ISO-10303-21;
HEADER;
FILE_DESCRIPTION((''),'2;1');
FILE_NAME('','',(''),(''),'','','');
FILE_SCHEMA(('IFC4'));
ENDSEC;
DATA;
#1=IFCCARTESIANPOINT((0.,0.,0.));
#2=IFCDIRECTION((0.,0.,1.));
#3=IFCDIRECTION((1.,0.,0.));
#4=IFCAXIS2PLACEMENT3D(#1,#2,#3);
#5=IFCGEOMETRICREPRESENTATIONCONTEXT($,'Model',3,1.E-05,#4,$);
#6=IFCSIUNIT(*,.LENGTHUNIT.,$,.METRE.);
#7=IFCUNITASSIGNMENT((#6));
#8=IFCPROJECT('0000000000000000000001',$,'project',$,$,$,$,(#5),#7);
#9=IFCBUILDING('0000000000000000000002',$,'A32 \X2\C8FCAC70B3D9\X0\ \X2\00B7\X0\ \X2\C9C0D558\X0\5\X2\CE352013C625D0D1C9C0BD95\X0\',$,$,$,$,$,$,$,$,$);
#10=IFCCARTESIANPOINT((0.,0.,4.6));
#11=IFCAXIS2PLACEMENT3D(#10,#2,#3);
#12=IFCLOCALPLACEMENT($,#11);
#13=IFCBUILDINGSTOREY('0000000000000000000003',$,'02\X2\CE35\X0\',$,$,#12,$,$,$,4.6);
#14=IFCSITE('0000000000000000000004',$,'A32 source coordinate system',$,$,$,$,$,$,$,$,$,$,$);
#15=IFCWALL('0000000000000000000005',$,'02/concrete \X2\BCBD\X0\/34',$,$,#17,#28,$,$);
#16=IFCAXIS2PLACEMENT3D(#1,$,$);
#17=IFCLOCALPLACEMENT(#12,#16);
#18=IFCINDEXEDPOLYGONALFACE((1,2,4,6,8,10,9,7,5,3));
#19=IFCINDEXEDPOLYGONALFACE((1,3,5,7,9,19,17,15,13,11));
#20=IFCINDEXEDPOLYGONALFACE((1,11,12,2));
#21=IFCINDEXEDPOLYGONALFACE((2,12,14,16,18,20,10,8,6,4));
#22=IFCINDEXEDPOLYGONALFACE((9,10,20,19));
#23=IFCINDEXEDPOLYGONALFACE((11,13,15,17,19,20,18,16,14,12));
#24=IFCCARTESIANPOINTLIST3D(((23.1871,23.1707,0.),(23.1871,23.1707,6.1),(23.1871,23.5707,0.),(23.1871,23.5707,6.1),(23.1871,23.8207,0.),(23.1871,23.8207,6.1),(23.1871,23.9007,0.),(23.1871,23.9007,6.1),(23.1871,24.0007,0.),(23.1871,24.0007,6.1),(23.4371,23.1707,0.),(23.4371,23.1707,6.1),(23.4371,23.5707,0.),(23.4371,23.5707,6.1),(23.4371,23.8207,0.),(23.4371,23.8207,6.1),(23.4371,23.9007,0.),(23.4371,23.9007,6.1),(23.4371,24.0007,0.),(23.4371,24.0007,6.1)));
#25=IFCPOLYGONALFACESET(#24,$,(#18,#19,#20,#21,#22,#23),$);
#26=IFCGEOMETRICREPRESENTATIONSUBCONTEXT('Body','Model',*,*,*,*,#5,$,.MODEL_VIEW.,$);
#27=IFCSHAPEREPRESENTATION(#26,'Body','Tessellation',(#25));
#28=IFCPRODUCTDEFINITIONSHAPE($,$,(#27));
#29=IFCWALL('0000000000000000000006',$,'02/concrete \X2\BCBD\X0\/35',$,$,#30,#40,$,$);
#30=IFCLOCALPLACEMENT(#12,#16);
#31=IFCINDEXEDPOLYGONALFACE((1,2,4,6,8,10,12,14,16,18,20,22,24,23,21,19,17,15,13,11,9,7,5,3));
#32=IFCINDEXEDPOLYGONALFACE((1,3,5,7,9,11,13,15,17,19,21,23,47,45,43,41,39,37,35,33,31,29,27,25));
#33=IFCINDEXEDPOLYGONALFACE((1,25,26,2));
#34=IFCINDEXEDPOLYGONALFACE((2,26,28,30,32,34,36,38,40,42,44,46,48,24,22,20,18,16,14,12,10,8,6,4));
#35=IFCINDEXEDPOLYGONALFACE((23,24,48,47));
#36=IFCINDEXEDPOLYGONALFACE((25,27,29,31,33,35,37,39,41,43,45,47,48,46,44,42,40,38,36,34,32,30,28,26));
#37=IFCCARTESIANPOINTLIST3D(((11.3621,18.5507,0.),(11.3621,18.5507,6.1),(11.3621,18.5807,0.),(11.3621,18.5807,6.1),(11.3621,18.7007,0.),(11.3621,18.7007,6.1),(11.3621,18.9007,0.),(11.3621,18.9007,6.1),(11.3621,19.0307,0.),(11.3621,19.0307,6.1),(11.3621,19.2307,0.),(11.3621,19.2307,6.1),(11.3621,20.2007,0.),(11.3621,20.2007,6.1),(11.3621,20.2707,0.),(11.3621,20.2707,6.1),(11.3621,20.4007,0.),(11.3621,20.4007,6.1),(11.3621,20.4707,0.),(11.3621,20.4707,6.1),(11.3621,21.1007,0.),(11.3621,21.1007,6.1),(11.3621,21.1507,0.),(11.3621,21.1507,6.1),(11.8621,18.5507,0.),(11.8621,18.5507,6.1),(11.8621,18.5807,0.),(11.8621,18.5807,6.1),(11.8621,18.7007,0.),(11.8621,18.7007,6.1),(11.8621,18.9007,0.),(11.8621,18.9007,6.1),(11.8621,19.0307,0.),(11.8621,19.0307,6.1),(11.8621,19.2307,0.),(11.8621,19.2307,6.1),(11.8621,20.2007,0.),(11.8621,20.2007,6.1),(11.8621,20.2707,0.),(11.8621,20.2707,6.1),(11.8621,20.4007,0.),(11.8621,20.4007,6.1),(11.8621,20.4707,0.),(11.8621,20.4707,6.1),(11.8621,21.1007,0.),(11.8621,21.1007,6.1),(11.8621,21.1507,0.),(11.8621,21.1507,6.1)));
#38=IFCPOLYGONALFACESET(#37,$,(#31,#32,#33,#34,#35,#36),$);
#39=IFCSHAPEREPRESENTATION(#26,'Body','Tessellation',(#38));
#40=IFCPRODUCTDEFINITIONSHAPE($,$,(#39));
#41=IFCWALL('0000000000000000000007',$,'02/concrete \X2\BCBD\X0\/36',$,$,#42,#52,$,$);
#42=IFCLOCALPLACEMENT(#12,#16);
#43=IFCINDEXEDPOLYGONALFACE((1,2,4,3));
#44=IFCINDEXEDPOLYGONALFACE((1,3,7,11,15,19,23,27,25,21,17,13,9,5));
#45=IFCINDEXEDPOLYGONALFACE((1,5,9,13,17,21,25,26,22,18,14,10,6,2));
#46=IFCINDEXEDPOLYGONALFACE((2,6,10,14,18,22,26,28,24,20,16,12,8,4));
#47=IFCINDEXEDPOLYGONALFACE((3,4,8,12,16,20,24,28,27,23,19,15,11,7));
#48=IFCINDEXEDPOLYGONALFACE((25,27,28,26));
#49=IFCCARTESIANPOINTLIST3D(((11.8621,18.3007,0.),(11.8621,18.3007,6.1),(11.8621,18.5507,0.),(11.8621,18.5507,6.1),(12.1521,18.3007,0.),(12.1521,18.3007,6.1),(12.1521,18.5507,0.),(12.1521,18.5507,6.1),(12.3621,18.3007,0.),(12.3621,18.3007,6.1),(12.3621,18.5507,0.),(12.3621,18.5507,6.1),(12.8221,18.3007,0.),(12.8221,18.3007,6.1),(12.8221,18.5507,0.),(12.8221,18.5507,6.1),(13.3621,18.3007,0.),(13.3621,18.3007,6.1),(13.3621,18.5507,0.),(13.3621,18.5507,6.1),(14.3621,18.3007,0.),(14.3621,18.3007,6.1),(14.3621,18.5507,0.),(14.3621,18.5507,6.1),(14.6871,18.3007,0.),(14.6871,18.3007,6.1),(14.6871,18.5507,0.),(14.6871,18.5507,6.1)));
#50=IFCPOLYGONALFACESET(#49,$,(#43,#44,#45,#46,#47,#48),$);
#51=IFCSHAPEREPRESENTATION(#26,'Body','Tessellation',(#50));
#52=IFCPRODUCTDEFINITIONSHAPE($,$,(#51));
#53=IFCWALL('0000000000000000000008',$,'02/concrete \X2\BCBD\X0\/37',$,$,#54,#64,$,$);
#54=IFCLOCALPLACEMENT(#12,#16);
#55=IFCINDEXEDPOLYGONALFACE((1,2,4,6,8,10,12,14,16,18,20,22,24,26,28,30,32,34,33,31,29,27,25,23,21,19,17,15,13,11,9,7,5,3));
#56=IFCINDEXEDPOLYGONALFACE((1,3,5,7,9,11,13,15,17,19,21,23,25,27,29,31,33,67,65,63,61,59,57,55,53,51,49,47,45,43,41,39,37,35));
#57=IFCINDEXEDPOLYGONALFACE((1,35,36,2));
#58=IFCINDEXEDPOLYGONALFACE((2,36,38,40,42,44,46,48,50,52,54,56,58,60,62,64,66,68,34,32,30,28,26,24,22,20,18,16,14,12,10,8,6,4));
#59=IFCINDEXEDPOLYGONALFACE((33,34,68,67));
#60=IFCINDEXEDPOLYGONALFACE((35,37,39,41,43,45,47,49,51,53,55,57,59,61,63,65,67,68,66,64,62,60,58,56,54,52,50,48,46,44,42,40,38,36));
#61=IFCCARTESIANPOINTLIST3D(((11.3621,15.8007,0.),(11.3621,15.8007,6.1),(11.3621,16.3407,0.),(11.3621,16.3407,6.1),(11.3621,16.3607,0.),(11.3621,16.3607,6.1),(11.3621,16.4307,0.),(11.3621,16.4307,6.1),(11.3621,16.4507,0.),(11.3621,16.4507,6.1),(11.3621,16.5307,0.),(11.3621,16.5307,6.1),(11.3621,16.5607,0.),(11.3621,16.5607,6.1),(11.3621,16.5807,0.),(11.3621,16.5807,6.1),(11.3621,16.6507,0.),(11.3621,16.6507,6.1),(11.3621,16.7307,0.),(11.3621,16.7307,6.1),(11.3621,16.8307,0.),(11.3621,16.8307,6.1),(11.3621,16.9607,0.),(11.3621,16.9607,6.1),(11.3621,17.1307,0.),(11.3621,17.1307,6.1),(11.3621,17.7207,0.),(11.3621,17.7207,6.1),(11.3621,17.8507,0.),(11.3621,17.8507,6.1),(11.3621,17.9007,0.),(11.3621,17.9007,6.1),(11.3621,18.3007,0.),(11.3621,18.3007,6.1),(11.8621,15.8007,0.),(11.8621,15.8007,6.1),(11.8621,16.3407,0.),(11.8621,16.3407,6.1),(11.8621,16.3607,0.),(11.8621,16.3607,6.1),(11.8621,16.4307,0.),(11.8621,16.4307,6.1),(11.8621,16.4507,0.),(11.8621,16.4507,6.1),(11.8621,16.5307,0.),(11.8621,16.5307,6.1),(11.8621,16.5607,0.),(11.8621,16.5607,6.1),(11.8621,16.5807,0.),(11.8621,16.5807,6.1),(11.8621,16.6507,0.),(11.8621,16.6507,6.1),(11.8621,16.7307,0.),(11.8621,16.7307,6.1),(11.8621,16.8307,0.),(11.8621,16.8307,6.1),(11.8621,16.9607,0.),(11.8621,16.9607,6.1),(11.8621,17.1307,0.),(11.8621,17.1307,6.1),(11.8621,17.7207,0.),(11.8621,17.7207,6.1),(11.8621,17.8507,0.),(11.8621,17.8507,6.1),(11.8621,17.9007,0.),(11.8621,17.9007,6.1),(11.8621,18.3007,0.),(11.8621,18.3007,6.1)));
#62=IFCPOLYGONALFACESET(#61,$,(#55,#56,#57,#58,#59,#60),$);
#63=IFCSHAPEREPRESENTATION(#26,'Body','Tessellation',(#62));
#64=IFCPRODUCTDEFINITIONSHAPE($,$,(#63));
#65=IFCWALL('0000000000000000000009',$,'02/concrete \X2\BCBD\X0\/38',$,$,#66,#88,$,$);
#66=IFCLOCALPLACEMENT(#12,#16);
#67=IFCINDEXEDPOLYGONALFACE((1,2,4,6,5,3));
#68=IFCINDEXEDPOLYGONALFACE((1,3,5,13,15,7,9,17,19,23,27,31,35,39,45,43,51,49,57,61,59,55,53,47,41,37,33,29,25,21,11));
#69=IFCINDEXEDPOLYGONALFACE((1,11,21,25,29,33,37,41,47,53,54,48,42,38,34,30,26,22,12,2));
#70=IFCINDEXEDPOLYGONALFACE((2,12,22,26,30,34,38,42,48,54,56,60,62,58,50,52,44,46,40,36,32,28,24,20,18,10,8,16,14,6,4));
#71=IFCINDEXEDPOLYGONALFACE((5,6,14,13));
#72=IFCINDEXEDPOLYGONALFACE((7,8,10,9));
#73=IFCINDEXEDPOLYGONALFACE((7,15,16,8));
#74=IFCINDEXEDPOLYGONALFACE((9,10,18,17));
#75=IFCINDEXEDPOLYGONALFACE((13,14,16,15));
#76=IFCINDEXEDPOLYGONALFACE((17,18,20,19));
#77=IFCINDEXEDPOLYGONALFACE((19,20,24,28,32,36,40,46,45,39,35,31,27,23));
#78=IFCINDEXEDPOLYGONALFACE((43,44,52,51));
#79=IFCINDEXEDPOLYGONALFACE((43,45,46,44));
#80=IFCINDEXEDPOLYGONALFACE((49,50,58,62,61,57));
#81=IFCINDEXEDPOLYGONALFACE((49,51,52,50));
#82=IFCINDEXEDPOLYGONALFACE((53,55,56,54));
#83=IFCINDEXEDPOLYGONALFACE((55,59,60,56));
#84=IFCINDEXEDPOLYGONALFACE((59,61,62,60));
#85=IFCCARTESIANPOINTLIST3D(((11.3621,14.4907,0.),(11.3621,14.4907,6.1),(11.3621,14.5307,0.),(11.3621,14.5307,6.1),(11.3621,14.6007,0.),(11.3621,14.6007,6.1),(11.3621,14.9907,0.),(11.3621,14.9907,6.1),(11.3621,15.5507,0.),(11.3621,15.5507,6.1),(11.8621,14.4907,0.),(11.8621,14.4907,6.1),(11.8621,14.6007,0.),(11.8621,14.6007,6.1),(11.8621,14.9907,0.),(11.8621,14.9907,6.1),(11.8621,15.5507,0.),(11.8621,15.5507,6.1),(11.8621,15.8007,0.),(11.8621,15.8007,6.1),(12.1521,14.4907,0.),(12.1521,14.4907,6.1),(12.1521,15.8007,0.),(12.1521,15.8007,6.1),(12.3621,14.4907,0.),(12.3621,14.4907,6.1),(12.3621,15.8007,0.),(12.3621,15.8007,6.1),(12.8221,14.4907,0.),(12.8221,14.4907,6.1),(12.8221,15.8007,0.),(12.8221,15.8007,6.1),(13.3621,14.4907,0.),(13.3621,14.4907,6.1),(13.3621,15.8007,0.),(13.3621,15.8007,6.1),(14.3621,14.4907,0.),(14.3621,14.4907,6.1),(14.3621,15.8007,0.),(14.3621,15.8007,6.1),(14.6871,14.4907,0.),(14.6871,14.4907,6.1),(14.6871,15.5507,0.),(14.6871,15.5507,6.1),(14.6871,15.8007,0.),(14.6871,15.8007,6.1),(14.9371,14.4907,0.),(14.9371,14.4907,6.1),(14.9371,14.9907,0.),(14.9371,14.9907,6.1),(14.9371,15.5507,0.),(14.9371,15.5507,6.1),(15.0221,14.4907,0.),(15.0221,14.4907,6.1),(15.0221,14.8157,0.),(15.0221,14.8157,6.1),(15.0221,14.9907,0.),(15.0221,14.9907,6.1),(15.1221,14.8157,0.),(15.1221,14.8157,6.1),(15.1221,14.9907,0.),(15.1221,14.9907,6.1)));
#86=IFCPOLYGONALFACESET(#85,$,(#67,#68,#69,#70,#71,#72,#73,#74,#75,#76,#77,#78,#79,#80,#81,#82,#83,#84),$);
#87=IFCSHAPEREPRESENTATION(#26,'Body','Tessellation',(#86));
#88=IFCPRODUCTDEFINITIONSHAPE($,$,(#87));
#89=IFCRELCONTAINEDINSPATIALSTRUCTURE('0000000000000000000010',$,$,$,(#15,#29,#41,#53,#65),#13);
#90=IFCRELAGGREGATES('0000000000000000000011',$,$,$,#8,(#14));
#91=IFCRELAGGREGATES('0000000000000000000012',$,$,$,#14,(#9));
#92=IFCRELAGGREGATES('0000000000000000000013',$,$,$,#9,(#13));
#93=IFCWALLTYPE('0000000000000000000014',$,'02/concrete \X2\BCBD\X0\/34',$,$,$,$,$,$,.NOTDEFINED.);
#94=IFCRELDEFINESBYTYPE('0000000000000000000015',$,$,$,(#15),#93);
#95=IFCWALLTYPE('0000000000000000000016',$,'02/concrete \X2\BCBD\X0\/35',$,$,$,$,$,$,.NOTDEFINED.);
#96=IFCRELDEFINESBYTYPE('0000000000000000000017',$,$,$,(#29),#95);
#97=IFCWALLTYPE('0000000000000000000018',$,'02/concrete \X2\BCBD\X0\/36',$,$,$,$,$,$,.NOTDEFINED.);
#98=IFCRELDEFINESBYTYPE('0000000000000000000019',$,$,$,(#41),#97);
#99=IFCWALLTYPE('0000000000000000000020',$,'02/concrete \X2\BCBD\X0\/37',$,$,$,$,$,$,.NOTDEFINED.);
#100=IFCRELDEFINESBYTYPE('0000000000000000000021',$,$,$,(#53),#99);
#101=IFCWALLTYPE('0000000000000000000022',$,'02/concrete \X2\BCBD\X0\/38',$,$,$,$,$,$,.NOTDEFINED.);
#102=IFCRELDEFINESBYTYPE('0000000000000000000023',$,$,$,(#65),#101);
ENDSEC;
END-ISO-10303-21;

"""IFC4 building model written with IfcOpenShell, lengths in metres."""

from ifc_helpers import new_model, si_unit, frame, origin, origin_with_axes, place, context, subcontext, project, spatial, polyline, outline, extrude, source, transform, mapped, type_object, type_shapes, element, save


model = new_model("IFC4")

# Units and contexts
model_context = context("Model", 3, precision=1e-05, world=origin_with_axes())
body_context = subcontext(model_context, "Body", "Model", "MODEL_VIEW")
ifc_project = project(units=[si_unit("LENGTHUNIT", "METRE")], contexts=[model_context])

# Site, building, storey
site = spatial("IfcSite", under=ifc_project, Name="A32 source coordinate system")
building = spatial("IfcBuilding", under=site, Name="A32 주거동 · 지하5층–옥탑지붕")
storey_placement = place(None, frame((0.0, 0.0, 4.6), z_axis=(0.0, 0.0, 1.0), x_axis=(1.0, 0.0, 0.0)))
storey = spatial("IfcBuildingStorey", under=building, at=storey_placement, Name="02층", Elevation=4.6)

# Walls
wall_type_1 = type_object("IfcWallType", Name="02/concrete 벽/34", PredefinedType="NOTDEFINED")
shared_shape_1 = source(origin(), body_context, "Body", "SweptSolid", [
    extrude(outline(polyline([(23.4371, 23.5707), (23.4371, 23.1707), (23.1871, 23.1707), (23.1871, 23.5707), (23.1871, 23.8207), (23.1871, 23.9007), (23.1871, 24.0007), (23.4371, 24.0007), (23.4371, 23.9007), (23.4371, 23.8207), (23.4371, 23.5707)])), origin(), (0.0, 0.0, 1.0), 6.1),
])
type_shapes(wall_type_1, [shared_shape_1])
wall_1_placement = place(storey_placement, origin_with_axes())
element("IfcWall", 1, at=wall_1_placement, inside=storey, type_object=wall_type_1, Name="02/concrete 벽/34", context=body_context, shape_type="MappedRepresentation", body=[
    mapped(shared_shape_1, transform((0.0, 0.0, 0.0), scale=1.0)),
])
wall_type_2 = type_object("IfcWallType", Name="02/concrete 벽/35", PredefinedType="NOTDEFINED")
shared_shape_2 = source(origin(), body_context, "Body", "SweptSolid", [
    extrude(outline(polyline([(11.3621, 19.0307), (11.3621, 19.2307), (11.3621, 20.2007), (11.3621, 20.2707), (11.3621, 20.4007), (11.3621, 20.4707), (11.3621, 21.1007), (11.3621, 21.1507), (11.8621, 21.1507), (11.8621, 21.1007), (11.8621, 20.4707), (11.8621, 20.4007), (11.8621, 20.2707), (11.8621, 20.2007), (11.8621, 19.2307), (11.8621, 19.0307), (11.8621, 18.9007), (11.8621, 18.7007), (11.8621, 18.5807), (11.8621, 18.5507), (11.3621, 18.5507), (11.3621, 18.5807), (11.3621, 18.7007), (11.3621, 18.9007), (11.3621, 19.0307)])), origin(), (0.0, 0.0, 1.0), 6.1),
])
type_shapes(wall_type_2, [shared_shape_2])
wall_2_placement = place(storey_placement, origin_with_axes())
element("IfcWall", 2, at=wall_2_placement, inside=storey, type_object=wall_type_2, Name="02/concrete 벽/35", context=body_context, shape_type="MappedRepresentation", body=[
    mapped(shared_shape_2, transform((0.0, 0.0, 0.0), scale=1.0)),
])
wall_type_3 = type_object("IfcWallType", Name="02/concrete 벽/36", PredefinedType="NOTDEFINED")
shared_shape_3 = source(origin(), body_context, "Body", "SweptSolid", [
    extrude(outline(polyline([(12.8221, 18.5507), (13.3621, 18.5507), (14.3621, 18.5507), (14.6871, 18.5507), (14.6871, 18.3007), (14.3621, 18.3007), (13.3621, 18.3007), (12.8221, 18.3007), (12.3621, 18.3007), (12.1521, 18.3007), (11.8621, 18.3007), (11.8621, 18.5507), (12.1521, 18.5507), (12.3621, 18.5507), (12.8221, 18.5507)])), origin(), (0.0, 0.0, 1.0), 6.1),
])
type_shapes(wall_type_3, [shared_shape_3])
wall_3_placement = place(storey_placement, origin_with_axes())
element("IfcWall", 3, at=wall_3_placement, inside=storey, type_object=wall_type_3, Name="02/concrete 벽/36", context=body_context, shape_type="MappedRepresentation", body=[
    mapped(shared_shape_3, transform((0.0, 0.0, 0.0), scale=1.0)),
])
wall_type_4 = type_object("IfcWallType", Name="02/concrete 벽/37", PredefinedType="NOTDEFINED")
shared_shape_4 = source(origin(), body_context, "Body", "SweptSolid", [
    extrude(outline(polyline([(11.8621, 17.7207), (11.8621, 17.1307), (11.8621, 16.9607), (11.8621, 16.8307), (11.8621, 16.7307), (11.8621, 16.6507), (11.8621, 16.5807), (11.8621, 16.5607), (11.8621, 16.5307), (11.8621, 16.4507), (11.8621, 16.4307), (11.8621, 16.3607), (11.8621, 16.3407), (11.8621, 15.8007), (11.3621, 15.8007), (11.3621, 16.3407), (11.3621, 16.3607), (11.3621, 16.4307), (11.3621, 16.4507), (11.3621, 16.5307), (11.3621, 16.5607), (11.3621, 16.5807), (11.3621, 16.6507), (11.3621, 16.7307), (11.3621, 16.8307), (11.3621, 16.9607), (11.3621, 17.1307), (11.3621, 17.7207), (11.3621, 17.8507), (11.3621, 17.9007), (11.3621, 18.3007), (11.8621, 18.3007), (11.8621, 17.9007), (11.8621, 17.8507), (11.8621, 17.7207)])), origin(), (0.0, 0.0, 1.0), 6.1),
])
type_shapes(wall_type_4, [shared_shape_4])
wall_4_placement = place(storey_placement, origin_with_axes())
element("IfcWall", 4, at=wall_4_placement, inside=storey, type_object=wall_type_4, Name="02/concrete 벽/37", context=body_context, shape_type="MappedRepresentation", body=[
    mapped(shared_shape_4, transform((0.0, 0.0, 0.0), scale=1.0)),
])
wall_type_5 = type_object("IfcWallType", Name="02/concrete 벽/38", PredefinedType="NOTDEFINED")
shared_shape_5 = source(origin(), body_context, "Body", "SweptSolid", [
    extrude(outline(polyline([(12.8221, 15.8007), (13.3621, 15.8007), (14.3621, 15.8007), (14.6871, 15.8007), (14.6871, 15.5507), (14.9371, 15.5507), (14.9371, 14.9907), (15.0221, 14.9907), (15.1221, 14.9907), (15.1221, 14.8157), (15.0221, 14.8157), (15.0221, 14.4907), (14.9371, 14.4907), (14.6871, 14.4907), (14.3621, 14.4907), (13.3621, 14.4907), (12.8221, 14.4907), (12.3621, 14.4907), (12.1521, 14.4907), (11.8621, 14.4907), (11.3621, 14.4907), (11.3621, 14.5307), (11.3621, 14.6007), (11.8621, 14.6007), (11.8621, 14.9907), (11.3621, 14.9907), (11.3621, 15.5507), (11.8621, 15.5507), (11.8621, 15.8007), (12.1521, 15.8007), (12.3621, 15.8007), (12.8221, 15.8007)])), origin(), (0.0, 0.0, 1.0), 6.1),
])
type_shapes(wall_type_5, [shared_shape_5])
wall_5_placement = place(storey_placement, origin_with_axes())
element("IfcWall", 5, at=wall_5_placement, inside=storey, type_object=wall_type_5, Name="02/concrete 벽/38", context=body_context, shape_type="MappedRepresentation", body=[
    mapped(shared_shape_5, transform((0.0, 0.0, 0.0), scale=1.0)),
])

save(model, "model.ifc")
